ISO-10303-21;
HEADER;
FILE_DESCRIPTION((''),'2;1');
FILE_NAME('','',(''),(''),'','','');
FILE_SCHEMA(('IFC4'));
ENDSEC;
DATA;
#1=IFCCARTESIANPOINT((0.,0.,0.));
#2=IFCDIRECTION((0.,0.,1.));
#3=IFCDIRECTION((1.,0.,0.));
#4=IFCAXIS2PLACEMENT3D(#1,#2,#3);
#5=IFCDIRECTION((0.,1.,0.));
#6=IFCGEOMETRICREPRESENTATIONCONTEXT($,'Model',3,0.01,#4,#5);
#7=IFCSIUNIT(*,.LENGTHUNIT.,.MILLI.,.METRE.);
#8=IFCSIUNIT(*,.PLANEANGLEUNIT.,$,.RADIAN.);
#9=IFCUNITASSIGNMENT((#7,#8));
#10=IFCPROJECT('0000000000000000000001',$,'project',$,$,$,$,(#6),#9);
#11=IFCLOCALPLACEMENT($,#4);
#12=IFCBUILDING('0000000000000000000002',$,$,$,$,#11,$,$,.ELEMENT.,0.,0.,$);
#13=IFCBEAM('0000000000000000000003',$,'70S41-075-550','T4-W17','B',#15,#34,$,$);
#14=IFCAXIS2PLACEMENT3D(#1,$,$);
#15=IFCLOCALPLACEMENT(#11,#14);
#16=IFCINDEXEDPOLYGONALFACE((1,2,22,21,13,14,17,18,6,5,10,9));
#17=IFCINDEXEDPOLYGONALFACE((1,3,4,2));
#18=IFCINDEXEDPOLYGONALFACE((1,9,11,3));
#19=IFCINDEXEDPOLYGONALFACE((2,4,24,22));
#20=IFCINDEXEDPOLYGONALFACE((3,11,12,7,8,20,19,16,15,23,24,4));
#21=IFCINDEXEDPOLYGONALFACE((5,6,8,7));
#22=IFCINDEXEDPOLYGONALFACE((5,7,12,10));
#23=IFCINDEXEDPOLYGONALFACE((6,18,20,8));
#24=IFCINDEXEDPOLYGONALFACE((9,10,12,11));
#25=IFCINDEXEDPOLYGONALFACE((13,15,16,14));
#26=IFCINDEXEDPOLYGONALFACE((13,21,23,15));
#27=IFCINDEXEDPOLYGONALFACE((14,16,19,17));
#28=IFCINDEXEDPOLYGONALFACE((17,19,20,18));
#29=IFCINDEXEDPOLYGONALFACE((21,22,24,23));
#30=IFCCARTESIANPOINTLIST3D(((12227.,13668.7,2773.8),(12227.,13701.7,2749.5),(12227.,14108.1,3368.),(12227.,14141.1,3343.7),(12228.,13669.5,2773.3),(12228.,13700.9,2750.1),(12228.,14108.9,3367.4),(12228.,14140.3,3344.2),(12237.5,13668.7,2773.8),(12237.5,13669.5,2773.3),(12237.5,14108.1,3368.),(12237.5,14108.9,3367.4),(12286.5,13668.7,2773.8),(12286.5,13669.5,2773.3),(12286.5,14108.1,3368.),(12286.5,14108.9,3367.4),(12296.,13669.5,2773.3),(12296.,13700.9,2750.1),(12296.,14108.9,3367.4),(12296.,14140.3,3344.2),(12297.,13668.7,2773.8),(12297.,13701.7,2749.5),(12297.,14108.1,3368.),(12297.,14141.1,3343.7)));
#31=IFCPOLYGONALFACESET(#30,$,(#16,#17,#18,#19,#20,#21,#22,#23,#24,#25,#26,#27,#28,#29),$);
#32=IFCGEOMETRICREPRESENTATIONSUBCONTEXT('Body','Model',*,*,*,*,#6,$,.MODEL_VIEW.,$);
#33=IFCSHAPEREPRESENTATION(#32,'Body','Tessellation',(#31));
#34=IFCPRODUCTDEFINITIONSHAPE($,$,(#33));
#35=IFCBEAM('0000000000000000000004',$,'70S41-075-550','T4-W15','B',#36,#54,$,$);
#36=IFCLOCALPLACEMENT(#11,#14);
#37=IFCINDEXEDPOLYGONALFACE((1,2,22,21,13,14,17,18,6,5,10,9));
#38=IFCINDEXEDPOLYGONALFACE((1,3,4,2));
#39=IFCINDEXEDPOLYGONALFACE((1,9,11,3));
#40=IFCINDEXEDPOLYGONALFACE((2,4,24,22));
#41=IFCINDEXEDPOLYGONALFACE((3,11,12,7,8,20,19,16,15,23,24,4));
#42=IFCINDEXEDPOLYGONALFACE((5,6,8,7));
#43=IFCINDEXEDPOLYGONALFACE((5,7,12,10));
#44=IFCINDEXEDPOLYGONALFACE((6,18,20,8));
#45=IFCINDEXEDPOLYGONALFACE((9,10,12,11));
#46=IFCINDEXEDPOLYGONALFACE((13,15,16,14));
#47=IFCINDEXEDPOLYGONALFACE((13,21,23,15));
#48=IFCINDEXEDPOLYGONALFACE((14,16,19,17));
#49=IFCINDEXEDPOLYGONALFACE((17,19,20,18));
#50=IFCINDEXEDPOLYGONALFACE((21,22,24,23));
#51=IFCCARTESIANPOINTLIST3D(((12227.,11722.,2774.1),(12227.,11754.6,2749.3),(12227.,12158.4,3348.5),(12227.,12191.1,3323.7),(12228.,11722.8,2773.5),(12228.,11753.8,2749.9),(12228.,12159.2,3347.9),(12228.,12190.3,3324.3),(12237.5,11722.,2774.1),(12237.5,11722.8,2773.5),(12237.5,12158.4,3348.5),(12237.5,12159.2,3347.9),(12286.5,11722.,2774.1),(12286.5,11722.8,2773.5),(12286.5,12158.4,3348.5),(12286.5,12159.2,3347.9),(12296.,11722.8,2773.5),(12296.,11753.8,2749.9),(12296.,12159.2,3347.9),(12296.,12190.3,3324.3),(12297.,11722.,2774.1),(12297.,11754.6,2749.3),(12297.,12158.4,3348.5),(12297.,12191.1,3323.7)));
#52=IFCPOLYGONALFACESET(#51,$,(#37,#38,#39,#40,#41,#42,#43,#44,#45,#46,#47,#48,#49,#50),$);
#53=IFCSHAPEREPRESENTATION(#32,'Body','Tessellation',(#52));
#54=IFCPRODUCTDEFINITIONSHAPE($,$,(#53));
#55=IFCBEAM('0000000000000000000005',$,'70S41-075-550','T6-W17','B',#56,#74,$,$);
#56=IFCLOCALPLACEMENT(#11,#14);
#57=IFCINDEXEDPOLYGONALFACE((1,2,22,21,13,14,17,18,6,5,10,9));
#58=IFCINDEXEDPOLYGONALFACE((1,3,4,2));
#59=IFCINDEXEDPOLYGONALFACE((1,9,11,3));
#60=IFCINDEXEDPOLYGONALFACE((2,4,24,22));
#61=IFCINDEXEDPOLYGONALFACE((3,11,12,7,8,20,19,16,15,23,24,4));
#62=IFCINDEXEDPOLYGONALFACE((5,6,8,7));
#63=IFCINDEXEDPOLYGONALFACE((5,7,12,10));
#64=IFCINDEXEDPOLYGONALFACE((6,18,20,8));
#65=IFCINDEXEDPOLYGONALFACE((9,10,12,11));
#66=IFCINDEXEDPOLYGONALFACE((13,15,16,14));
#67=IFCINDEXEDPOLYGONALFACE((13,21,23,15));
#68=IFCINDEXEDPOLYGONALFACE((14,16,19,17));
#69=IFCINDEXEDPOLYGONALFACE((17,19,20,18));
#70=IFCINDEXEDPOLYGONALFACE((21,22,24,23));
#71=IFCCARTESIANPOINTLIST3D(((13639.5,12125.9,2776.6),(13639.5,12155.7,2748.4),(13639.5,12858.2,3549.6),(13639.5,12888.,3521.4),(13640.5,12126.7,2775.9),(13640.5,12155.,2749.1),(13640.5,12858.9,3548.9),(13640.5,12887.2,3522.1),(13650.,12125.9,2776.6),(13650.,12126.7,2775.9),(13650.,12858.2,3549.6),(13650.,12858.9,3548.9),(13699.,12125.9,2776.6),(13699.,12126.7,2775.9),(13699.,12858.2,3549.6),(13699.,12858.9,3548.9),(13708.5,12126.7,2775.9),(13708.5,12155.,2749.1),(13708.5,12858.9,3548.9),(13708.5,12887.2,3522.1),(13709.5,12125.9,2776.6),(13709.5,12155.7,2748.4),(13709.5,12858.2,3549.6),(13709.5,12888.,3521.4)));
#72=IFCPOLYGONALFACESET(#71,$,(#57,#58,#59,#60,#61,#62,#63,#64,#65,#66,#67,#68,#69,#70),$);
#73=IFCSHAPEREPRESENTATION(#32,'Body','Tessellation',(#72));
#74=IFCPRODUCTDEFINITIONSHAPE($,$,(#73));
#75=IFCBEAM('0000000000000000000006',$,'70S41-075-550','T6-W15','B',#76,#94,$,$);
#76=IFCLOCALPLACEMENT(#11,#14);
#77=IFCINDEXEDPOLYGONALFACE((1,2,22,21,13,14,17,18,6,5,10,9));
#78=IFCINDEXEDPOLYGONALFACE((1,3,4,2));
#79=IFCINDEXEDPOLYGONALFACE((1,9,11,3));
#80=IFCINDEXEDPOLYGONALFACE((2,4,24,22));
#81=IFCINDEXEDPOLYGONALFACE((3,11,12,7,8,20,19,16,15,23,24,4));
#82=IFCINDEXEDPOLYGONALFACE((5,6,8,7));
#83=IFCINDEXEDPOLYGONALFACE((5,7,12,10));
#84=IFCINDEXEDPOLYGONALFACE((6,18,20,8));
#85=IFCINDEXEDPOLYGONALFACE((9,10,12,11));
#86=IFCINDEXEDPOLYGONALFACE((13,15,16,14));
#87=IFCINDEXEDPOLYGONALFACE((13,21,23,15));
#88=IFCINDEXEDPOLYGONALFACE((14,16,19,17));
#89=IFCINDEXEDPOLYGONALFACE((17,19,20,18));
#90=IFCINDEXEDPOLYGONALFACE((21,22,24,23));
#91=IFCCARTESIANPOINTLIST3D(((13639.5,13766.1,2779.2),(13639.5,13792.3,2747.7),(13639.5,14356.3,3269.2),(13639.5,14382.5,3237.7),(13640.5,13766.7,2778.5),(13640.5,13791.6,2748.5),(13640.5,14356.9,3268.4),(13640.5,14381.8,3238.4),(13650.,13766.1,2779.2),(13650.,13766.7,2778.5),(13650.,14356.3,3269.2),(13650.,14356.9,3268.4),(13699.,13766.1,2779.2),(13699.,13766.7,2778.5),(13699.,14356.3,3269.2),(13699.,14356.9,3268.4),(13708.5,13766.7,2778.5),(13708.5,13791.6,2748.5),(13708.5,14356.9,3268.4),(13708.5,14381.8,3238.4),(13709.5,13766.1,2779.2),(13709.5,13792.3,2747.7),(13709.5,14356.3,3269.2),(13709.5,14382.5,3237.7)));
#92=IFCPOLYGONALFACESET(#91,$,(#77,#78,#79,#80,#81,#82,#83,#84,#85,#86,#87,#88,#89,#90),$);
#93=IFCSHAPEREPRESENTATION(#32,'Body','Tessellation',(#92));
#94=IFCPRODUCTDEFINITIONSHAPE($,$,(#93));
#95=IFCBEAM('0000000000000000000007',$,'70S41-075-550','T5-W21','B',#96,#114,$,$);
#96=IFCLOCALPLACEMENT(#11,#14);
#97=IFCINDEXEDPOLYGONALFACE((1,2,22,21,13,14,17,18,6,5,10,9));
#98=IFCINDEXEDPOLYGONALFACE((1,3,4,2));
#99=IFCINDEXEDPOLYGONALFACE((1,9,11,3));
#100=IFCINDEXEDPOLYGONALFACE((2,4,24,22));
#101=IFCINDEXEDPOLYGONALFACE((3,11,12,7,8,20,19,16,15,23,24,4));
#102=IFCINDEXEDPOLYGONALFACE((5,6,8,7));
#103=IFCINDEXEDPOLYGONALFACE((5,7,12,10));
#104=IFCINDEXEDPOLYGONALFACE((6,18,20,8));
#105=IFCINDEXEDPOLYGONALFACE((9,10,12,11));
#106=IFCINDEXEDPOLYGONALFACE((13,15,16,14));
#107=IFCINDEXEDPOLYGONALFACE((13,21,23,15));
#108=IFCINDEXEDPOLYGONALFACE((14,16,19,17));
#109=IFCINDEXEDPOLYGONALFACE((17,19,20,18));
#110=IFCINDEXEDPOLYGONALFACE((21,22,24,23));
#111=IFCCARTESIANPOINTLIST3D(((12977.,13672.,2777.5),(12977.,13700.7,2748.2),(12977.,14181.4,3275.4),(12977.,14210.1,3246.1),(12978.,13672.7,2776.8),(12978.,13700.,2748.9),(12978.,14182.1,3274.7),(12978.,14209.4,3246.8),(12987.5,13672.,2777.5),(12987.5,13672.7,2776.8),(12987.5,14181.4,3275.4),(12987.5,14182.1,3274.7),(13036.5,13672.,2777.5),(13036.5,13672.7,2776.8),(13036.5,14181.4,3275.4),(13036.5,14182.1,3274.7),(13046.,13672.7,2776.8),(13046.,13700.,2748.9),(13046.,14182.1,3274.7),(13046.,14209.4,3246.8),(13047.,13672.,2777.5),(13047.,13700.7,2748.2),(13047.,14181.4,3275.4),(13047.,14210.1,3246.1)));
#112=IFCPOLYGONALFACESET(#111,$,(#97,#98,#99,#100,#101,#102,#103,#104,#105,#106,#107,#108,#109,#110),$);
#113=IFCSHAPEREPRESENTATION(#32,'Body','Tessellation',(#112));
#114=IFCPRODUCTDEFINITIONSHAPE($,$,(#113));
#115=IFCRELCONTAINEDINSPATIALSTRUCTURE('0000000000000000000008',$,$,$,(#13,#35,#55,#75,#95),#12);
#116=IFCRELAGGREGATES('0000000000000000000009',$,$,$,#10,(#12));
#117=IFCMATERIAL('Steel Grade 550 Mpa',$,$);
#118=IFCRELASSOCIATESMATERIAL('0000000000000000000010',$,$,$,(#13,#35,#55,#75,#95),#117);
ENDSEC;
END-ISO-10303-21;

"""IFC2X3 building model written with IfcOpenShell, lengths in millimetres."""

from ifc_helpers import new_model, si_unit, direction, frame, origin, origin_with_axes, origin_2d_with_axis, place, context, subcontext, project, spatial, c_section, extrude, source, transform, mapped, material, element, save


model = new_model("IFC2X3")

# Units and contexts
model_context = context("Model", 3, precision=0.01, world=origin_with_axes(), true_north=direction((0.0, 1.0, 0.0)))
body_context = subcontext(model_context, "Body", "Model", "MODEL_VIEW")
ifc_project = project(units=[si_unit("LENGTHUNIT", "METRE", prefix="MILLI"), si_unit("PLANEANGLEUNIT", "RADIAN")], contexts=[model_context])

# Building
building_placement = place(None, origin_with_axes())
building = spatial("IfcBuilding", under=ifc_project, at=building_placement, CompositionType="ELEMENT", ElevationOfRefHeight=0.0, ElevationOfTerrain=0.0)

# Shared definitions
ifc_material = material(Name="Steel Grade 550 Mpa")

# Beams
shared_shape_1 = source(origin(), body_context, "Body", "SweptSolid", [
    extrude(c_section(Depth=70.0, Width=41.0, WallThickness=1.0, Girth=10.5, at=origin_2d_with_axis()), origin_with_axes(), (0.0, 0.0, 1.0), 739.0),
])
beam_1_placement = place(None, frame((12262.0, 13685.2, 2761.7), z_axis=(0.0, 0.594622, 0.804005), x_axis=(0.0, -0.804005, 0.594622)))
element("IfcBeam", 1, at=beam_1_placement, inside=building, material=ifc_material, Name="70S41-075-550", Description="T4-W17", ObjectType="B", context=body_context, shape_type="MappedRepresentation", body=[
    mapped(shared_shape_1, transform((0.0, 0.0, 0.0), scale=1.0)),
])
shared_shape_2 = source(origin(), body_context, "Body", "SweptSolid", [
    extrude(c_section(Depth=70.0, Width=41.0, WallThickness=1.0, Girth=10.5, at=origin_2d_with_axis()), origin_with_axes(), (0.0, 0.0, 1.0), 721.4),
])
beam_2_placement = place(None, frame((12262.0, 11738.3, 2761.7), z_axis=(0.0, 0.60497, 0.796248), x_axis=(0.0, -0.796248, 0.60497)))
element("IfcBeam", 2, at=beam_2_placement, inside=building, material=ifc_material, Name="70S41-075-550", Description="T4-W15", ObjectType="B", context=body_context, shape_type="MappedRepresentation", body=[
    mapped(shared_shape_2, transform((0.0, 0.0, 0.0), scale=1.0)),
])
shared_shape_3 = source(origin(), body_context, "Body", "SweptSolid", [
    extrude(c_section(Depth=70.0, Width=41.0, WallThickness=1.0, Girth=10.5, at=origin_2d_with_axis()), origin_with_axes(), (0.0, 0.0, 1.0), 1064.7),
])
beam_3_placement = place(None, frame((13674.5, 12140.8, 2762.5), z_axis=(-0.000002, 0.687731, 0.725965), x_axis=(0.000003, -0.725965, 0.687731)))
element("IfcBeam", 3, at=beam_3_placement, inside=building, material=ifc_material, Name="70S41-075-550", Description="T6-W17", ObjectType="B", context=body_context, shape_type="MappedRepresentation", body=[
    mapped(shared_shape_3, transform((0.0, 0.0, 0.0), scale=1.0)),
])
shared_shape_4 = source(origin(), body_context, "Body", "SweptSolid", [
    extrude(c_section(Depth=70.0, Width=41.0, WallThickness=1.0, Girth=10.5, at=origin_2d_with_axis()), origin_with_axes(), (0.0, 0.0, 1.0), 767.1),
])
beam_4_placement = place(None, frame((13674.5, 13779.2, 2763.5), z_axis=(-0.000003, 0.76942, 0.638743), x_axis=(0.000002, -0.638743, 0.76942)))
element("IfcBeam", 4, at=beam_4_placement, inside=building, material=ifc_material, Name="70S41-075-550", Description="T6-W15", ObjectType="B", context=body_context, shape_type="MappedRepresentation", body=[
    mapped(shared_shape_4, transform((0.0, 0.0, 0.0), scale=1.0)),
])
shared_shape_5 = source(origin(), body_context, "Body", "SweptSolid", [
    extrude(c_section(Depth=70.0, Width=41.0, WallThickness=1.0, Girth=10.5, at=origin_2d_with_axis()), origin_with_axes(), (0.0, 0.0, 1.0), 712.4),
])
beam_5_placement = place(None, frame((13012.0, 13686.4, 2762.8), z_axis=(-0.000003, 0.715063, 0.69906), x_axis=(0.000003, -0.69906, 0.715063)))
element("IfcBeam", 5, at=beam_5_placement, inside=building, material=ifc_material, Name="70S41-075-550", Description="T5-W21", ObjectType="B", context=body_context, shape_type="MappedRepresentation", body=[
    mapped(shared_shape_5, transform((0.0, 0.0, 0.0), scale=1.0)),
])

save(model, "model.ifc")
